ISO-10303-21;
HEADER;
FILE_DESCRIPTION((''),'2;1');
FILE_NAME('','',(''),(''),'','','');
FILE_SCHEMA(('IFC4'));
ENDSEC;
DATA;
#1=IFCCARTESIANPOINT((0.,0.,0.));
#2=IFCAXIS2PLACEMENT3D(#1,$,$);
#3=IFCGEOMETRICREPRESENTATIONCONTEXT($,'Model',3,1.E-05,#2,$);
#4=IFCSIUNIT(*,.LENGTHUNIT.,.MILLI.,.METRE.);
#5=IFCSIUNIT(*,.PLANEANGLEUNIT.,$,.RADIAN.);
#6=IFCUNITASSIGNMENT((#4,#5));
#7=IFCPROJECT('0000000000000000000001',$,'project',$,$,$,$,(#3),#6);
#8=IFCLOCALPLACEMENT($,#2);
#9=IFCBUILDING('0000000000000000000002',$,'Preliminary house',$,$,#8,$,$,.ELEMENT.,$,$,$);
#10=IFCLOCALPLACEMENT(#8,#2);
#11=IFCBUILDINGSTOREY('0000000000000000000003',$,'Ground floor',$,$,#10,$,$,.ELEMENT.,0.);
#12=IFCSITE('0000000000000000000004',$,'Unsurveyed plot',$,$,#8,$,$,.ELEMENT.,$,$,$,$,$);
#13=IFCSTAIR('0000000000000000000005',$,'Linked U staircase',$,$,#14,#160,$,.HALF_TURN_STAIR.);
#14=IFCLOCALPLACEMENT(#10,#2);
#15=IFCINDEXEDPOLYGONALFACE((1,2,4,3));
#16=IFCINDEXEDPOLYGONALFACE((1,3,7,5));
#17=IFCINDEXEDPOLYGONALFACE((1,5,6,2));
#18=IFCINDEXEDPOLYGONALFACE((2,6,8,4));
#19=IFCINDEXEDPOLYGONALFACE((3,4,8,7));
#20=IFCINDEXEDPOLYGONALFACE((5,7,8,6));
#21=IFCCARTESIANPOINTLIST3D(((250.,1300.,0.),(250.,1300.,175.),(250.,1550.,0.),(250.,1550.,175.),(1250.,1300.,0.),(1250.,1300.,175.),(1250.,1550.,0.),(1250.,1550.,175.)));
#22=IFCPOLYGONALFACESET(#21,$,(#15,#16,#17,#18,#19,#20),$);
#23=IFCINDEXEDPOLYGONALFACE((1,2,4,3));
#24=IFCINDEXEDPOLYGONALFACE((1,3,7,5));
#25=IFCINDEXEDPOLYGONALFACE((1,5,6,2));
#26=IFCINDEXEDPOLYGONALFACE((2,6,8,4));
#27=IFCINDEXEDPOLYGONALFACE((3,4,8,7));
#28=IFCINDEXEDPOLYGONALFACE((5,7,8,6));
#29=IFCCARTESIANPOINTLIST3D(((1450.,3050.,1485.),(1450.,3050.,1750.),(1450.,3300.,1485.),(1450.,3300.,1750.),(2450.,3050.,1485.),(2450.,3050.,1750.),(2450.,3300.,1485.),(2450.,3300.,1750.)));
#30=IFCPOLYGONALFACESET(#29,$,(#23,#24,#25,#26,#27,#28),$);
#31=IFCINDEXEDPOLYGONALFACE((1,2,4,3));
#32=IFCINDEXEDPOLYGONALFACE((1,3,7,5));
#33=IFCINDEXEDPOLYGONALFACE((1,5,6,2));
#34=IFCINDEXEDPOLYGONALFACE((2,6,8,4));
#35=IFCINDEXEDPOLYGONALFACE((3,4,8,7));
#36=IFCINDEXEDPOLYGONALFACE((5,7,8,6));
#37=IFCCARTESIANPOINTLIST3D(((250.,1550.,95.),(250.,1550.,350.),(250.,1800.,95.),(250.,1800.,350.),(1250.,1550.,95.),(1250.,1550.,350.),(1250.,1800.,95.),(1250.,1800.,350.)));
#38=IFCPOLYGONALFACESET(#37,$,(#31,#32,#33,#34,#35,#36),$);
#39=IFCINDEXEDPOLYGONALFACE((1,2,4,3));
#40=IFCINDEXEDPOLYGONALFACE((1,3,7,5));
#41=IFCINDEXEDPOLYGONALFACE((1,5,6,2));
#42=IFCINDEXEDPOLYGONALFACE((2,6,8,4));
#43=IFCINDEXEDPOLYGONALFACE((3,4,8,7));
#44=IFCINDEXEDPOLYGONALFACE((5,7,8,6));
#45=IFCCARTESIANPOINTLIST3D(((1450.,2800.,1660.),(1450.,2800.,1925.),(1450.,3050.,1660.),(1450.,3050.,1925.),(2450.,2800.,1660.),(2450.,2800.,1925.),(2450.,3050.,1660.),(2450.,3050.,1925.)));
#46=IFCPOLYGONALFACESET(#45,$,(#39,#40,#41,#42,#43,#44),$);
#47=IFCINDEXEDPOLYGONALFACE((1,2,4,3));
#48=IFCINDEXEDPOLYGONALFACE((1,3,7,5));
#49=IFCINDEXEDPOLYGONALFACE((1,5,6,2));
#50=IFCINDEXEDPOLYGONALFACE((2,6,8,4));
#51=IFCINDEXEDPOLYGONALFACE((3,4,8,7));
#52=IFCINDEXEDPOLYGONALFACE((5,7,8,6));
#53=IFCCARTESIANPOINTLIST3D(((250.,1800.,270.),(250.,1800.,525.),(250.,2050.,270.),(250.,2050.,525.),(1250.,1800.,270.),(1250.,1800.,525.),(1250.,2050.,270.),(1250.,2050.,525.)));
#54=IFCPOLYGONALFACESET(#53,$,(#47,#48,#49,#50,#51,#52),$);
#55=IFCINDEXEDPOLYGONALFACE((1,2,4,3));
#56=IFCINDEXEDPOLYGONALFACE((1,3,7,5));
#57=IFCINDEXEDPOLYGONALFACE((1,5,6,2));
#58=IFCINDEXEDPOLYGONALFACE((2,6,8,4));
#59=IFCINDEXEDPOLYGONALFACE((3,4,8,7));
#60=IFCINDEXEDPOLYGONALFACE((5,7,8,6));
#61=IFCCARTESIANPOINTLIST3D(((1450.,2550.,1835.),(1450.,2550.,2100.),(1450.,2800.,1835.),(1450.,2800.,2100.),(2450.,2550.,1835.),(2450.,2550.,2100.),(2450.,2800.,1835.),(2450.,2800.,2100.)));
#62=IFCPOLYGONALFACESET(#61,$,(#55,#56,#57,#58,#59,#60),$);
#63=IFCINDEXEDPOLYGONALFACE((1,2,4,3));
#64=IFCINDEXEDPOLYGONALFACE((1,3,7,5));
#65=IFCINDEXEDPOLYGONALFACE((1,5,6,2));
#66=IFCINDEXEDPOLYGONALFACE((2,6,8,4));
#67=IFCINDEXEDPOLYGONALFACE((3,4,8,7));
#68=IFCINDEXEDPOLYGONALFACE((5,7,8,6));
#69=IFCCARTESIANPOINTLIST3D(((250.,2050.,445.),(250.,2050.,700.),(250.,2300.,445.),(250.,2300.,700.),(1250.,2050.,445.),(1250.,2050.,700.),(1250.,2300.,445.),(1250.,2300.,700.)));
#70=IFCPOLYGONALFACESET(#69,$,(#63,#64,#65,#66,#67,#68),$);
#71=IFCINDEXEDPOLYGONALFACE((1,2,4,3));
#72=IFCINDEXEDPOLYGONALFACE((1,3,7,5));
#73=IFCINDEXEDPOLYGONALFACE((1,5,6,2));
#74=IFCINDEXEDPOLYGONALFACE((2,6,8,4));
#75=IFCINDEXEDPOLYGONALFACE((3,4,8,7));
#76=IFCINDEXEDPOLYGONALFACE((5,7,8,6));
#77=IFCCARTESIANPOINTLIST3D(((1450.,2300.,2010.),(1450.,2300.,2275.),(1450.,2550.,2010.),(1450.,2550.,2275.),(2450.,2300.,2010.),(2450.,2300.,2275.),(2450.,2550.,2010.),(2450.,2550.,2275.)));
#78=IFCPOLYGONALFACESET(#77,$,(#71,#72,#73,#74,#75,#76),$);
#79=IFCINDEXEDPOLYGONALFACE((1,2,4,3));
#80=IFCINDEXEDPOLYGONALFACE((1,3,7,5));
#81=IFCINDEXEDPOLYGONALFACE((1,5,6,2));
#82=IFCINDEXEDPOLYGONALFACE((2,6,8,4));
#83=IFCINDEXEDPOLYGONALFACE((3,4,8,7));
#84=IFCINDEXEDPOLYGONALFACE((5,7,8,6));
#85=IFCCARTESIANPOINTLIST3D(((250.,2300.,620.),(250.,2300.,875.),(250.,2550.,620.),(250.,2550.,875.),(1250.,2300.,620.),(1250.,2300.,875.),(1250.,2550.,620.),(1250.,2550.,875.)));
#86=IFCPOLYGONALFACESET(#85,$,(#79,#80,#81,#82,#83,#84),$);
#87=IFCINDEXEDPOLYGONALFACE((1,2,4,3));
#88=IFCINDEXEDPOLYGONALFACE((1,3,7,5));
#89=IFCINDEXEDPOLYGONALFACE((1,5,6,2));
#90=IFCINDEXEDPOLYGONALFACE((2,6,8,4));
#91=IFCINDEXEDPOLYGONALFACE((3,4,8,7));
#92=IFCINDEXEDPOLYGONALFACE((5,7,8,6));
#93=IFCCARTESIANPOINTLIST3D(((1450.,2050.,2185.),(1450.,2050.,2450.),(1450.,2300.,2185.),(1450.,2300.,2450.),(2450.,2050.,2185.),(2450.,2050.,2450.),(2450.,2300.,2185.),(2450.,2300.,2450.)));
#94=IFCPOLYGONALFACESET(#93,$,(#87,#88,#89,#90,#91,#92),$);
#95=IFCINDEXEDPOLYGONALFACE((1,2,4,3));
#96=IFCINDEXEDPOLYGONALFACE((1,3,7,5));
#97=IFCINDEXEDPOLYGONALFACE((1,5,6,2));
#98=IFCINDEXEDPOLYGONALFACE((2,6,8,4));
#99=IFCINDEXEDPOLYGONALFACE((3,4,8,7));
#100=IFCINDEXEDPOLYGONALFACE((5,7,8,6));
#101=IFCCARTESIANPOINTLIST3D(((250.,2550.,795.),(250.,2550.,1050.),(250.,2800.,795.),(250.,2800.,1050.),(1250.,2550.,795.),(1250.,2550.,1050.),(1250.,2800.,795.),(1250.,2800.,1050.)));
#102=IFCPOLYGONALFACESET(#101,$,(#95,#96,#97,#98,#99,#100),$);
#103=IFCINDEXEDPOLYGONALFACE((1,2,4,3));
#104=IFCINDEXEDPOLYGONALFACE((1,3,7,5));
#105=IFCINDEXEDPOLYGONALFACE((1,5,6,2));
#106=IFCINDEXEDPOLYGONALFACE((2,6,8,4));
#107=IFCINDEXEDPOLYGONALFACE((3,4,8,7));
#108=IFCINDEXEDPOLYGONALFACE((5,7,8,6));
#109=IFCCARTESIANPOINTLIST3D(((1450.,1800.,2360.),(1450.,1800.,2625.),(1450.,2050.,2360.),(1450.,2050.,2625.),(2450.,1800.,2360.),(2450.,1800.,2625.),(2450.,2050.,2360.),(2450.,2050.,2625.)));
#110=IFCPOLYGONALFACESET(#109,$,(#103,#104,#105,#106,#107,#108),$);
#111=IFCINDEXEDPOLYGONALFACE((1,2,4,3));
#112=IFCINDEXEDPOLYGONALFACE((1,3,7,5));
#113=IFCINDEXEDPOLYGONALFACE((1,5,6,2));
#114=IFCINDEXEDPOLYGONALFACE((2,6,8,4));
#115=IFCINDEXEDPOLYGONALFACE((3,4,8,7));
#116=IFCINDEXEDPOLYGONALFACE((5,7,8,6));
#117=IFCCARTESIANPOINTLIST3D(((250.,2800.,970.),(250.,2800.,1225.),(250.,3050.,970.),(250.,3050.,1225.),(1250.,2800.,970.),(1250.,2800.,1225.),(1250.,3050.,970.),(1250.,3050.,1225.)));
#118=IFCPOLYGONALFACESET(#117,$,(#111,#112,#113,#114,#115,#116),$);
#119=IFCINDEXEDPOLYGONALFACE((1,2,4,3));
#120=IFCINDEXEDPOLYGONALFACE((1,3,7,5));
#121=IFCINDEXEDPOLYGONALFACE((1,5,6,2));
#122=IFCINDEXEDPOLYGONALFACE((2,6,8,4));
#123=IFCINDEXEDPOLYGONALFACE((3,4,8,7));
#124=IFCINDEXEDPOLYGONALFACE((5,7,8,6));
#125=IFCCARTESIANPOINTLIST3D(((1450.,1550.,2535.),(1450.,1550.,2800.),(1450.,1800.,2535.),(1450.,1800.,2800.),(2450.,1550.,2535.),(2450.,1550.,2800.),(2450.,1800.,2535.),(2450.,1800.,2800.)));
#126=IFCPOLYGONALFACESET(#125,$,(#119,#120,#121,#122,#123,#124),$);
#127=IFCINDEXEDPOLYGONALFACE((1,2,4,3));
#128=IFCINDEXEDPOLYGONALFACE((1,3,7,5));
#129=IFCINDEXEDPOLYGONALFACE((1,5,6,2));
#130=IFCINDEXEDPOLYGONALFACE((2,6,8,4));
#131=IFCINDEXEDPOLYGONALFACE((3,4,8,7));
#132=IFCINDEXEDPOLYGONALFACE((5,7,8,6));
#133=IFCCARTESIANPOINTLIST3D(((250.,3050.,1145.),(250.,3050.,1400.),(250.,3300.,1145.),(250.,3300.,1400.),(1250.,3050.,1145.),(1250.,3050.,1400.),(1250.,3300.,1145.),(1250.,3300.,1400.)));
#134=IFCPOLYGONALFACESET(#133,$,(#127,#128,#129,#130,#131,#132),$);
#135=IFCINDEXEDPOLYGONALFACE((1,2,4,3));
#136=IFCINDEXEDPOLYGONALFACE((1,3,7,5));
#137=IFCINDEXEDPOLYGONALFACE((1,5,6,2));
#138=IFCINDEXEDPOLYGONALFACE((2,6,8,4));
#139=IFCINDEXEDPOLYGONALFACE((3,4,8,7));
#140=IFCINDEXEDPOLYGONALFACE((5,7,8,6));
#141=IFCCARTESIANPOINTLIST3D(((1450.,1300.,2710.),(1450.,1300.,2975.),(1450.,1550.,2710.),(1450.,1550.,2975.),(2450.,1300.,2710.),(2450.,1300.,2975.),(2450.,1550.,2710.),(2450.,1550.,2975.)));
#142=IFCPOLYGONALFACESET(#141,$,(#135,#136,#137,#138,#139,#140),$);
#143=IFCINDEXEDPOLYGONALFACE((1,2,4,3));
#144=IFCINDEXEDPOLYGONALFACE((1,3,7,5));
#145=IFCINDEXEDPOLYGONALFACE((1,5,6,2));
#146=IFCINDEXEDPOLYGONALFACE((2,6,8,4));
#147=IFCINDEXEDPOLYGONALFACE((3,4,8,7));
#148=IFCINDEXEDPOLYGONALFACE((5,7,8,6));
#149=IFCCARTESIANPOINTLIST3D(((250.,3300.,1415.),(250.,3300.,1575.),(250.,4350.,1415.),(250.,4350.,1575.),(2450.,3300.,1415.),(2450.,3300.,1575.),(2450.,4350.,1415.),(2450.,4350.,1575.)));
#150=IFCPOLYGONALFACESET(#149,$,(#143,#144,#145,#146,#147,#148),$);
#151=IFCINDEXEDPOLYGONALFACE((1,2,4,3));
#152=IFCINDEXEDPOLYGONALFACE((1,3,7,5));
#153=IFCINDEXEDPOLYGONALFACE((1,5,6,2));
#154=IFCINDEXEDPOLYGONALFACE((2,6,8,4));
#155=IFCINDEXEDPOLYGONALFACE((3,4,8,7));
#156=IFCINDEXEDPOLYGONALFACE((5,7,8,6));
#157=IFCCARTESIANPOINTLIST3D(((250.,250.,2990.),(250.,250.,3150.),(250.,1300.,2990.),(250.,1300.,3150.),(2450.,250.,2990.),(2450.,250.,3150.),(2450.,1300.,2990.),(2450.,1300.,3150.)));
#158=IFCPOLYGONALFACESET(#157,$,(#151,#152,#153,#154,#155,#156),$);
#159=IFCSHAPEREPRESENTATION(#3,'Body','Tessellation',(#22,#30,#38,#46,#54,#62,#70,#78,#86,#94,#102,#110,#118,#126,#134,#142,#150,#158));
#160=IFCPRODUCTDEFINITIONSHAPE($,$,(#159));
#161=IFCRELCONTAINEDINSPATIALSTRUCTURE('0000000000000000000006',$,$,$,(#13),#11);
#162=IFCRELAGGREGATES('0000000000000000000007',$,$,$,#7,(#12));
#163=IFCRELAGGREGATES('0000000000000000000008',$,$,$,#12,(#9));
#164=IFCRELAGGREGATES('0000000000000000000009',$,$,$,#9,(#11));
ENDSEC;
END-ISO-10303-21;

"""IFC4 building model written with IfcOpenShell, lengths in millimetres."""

from ifc_helpers import new_model, si_unit, frame, origin, place, context, project, spatial, polyline, outline, extrude, element, save


model = new_model("IFC4")

# Units and contexts
model_context = context("Model", 3, precision=1e-05, world=origin())
ifc_project = project(units=[si_unit("LENGTHUNIT", "METRE", prefix="MILLI"), si_unit("PLANEANGLEUNIT", "RADIAN")], contexts=[model_context])

# Site, building, storey
placement_1 = place(None, origin())
site = spatial("IfcSite", under=ifc_project, at=placement_1, Name="Unsurveyed plot", CompositionType="ELEMENT")
building = spatial("IfcBuilding", under=site, at=placement_1, Name="Preliminary house", CompositionType="ELEMENT")
placement_2 = place(placement_1, origin())
storey = spatial("IfcBuildingStorey", under=building, at=placement_2, Name="Ground floor", CompositionType="ELEMENT", Elevation=0.0)

# Stair
element("IfcStair", 1, at=placement_2, inside=storey, Name="Linked U staircase", PredefinedType="HALF_TURN_STAIR", context=model_context, shape_type="SweptSolid", body=[
    extrude(outline(polyline([(1250.0, 1300.0), (1250.0, 1550.0), (250.0, 1550.0), (250.0, 1300.0), (1250.0, 1300.0)])), origin(), (0.0, 0.0, 1.0), 175.0),
    extrude(outline(polyline([(2450.0, 3050.0), (2450.0, 3300.0), (1450.0, 3300.0), (1450.0, 3050.0), (2450.0, 3050.0)])), frame((0.0, 0.0, 1485.0)), (0.0, 0.0, 1.0), 265.0),
    extrude(outline(polyline([(1250.0, 1550.0), (1250.0, 1800.0), (250.0, 1800.0), (250.0, 1550.0), (1250.0, 1550.0)])), frame((0.0, 0.0, 95.0)), (0.0, 0.0, 1.0), 255.0),
    extrude(outline(polyline([(2450.0, 2800.0), (2450.0, 3050.0), (1450.0, 3050.0), (1450.0, 2800.0), (2450.0, 2800.0)])), frame((0.0, 0.0, 1660.0)), (0.0, 0.0, 1.0), 265.0),
    extrude(outline(polyline([(1250.0, 1800.0), (1250.0, 2050.0), (250.0, 2050.0), (250.0, 1800.0), (1250.0, 1800.0)])), frame((0.0, 0.0, 270.0)), (0.0, 0.0, 1.0), 255.0),
    extrude(outline(polyline([(2450.0, 2550.0), (2450.0, 2800.0), (1450.0, 2800.0), (1450.0, 2550.0), (2450.0, 2550.0)])), frame((0.0, 0.0, 1835.0)), (0.0, 0.0, 1.0), 265.0),
    extrude(outline(polyline([(1250.0, 2050.0), (1250.0, 2300.0), (250.0, 2300.0), (250.0, 2050.0), (1250.0, 2050.0)])), frame((0.0, 0.0, 445.0)), (0.0, 0.0, 1.0), 255.0),
    extrude(outline(polyline([(2450.0, 2300.0), (2450.0, 2550.0), (1450.0, 2550.0), (1450.0, 2300.0), (2450.0, 2300.0)])), frame((0.0, 0.0, 2010.0)), (0.0, 0.0, 1.0), 265.0),
    extrude(outline(polyline([(1250.0, 2300.0), (1250.0, 2550.0), (250.0, 2550.0), (250.0, 2300.0), (1250.0, 2300.0)])), frame((0.0, 0.0, 620.0)), (0.0, 0.0, 1.0), 255.0),
    extrude(outline(polyline([(2450.0, 2050.0), (2450.0, 2300.0), (1450.0, 2300.0), (1450.0, 2050.0), (2450.0, 2050.0)])), frame((0.0, 0.0, 2185.0)), (0.0, 0.0, 1.0), 265.0),
    extrude(outline(polyline([(1250.0, 2550.0), (1250.0, 2800.0), (250.0, 2800.0), (250.0, 2550.0), (1250.0, 2550.0)])), frame((0.0, 0.0, 795.0)), (0.0, 0.0, 1.0), 255.0),
    extrude(outline(polyline([(2450.0, 1800.0), (2450.0, 2050.0), (1450.0, 2050.0), (1450.0, 1800.0), (2450.0, 1800.0)])), frame((0.0, 0.0, 2360.0)), (0.0, 0.0, 1.0), 265.0),
    extrude(outline(polyline([(1250.0, 2800.0), (1250.0, 3050.0), (250.0, 3050.0), (250.0, 2800.0), (1250.0, 2800.0)])), frame((0.0, 0.0, 970.0)), (0.0, 0.0, 1.0), 255.0),
    extrude(outline(polyline([(2450.0, 1550.0), (2450.0, 1800.0), (1450.0, 1800.0), (1450.0, 1550.0), (2450.0, 1550.0)])), frame((0.0, 0.0, 2535.0)), (0.0, 0.0, 1.0), 265.0),
    extrude(outline(polyline([(1250.0, 3050.0), (1250.0, 3300.0), (250.0, 3300.0), (250.0, 3050.0), (1250.0, 3050.0)])), frame((0.0, 0.0, 1145.0)), (0.0, 0.0, 1.0), 255.0),
    extrude(outline(polyline([(2450.0, 1300.0), (2450.0, 1550.0), (1450.0, 1550.0), (1450.0, 1300.0), (2450.0, 1300.0)])), frame((0.0, 0.0, 2710.0)), (0.0, 0.0, 1.0), 265.0),
    extrude(outline(polyline([(2450.0, 3300.0), (2450.0, 4350.0), (250.0, 4350.0), (250.0, 3300.0), (2450.0, 3300.0)])), frame((0.0, 0.0, 1415.0)), (0.0, 0.0, 1.0), 160.0),
    extrude(outline(polyline([(2450.0, 250.0), (2450.0, 1300.0), (250.0, 1300.0), (250.0, 250.0), (2450.0, 250.0)])), frame((0.0, 0.0, 2990.0)), (0.0, 0.0, 1.0), 160.0),
])

save(model, "model.ifc")
